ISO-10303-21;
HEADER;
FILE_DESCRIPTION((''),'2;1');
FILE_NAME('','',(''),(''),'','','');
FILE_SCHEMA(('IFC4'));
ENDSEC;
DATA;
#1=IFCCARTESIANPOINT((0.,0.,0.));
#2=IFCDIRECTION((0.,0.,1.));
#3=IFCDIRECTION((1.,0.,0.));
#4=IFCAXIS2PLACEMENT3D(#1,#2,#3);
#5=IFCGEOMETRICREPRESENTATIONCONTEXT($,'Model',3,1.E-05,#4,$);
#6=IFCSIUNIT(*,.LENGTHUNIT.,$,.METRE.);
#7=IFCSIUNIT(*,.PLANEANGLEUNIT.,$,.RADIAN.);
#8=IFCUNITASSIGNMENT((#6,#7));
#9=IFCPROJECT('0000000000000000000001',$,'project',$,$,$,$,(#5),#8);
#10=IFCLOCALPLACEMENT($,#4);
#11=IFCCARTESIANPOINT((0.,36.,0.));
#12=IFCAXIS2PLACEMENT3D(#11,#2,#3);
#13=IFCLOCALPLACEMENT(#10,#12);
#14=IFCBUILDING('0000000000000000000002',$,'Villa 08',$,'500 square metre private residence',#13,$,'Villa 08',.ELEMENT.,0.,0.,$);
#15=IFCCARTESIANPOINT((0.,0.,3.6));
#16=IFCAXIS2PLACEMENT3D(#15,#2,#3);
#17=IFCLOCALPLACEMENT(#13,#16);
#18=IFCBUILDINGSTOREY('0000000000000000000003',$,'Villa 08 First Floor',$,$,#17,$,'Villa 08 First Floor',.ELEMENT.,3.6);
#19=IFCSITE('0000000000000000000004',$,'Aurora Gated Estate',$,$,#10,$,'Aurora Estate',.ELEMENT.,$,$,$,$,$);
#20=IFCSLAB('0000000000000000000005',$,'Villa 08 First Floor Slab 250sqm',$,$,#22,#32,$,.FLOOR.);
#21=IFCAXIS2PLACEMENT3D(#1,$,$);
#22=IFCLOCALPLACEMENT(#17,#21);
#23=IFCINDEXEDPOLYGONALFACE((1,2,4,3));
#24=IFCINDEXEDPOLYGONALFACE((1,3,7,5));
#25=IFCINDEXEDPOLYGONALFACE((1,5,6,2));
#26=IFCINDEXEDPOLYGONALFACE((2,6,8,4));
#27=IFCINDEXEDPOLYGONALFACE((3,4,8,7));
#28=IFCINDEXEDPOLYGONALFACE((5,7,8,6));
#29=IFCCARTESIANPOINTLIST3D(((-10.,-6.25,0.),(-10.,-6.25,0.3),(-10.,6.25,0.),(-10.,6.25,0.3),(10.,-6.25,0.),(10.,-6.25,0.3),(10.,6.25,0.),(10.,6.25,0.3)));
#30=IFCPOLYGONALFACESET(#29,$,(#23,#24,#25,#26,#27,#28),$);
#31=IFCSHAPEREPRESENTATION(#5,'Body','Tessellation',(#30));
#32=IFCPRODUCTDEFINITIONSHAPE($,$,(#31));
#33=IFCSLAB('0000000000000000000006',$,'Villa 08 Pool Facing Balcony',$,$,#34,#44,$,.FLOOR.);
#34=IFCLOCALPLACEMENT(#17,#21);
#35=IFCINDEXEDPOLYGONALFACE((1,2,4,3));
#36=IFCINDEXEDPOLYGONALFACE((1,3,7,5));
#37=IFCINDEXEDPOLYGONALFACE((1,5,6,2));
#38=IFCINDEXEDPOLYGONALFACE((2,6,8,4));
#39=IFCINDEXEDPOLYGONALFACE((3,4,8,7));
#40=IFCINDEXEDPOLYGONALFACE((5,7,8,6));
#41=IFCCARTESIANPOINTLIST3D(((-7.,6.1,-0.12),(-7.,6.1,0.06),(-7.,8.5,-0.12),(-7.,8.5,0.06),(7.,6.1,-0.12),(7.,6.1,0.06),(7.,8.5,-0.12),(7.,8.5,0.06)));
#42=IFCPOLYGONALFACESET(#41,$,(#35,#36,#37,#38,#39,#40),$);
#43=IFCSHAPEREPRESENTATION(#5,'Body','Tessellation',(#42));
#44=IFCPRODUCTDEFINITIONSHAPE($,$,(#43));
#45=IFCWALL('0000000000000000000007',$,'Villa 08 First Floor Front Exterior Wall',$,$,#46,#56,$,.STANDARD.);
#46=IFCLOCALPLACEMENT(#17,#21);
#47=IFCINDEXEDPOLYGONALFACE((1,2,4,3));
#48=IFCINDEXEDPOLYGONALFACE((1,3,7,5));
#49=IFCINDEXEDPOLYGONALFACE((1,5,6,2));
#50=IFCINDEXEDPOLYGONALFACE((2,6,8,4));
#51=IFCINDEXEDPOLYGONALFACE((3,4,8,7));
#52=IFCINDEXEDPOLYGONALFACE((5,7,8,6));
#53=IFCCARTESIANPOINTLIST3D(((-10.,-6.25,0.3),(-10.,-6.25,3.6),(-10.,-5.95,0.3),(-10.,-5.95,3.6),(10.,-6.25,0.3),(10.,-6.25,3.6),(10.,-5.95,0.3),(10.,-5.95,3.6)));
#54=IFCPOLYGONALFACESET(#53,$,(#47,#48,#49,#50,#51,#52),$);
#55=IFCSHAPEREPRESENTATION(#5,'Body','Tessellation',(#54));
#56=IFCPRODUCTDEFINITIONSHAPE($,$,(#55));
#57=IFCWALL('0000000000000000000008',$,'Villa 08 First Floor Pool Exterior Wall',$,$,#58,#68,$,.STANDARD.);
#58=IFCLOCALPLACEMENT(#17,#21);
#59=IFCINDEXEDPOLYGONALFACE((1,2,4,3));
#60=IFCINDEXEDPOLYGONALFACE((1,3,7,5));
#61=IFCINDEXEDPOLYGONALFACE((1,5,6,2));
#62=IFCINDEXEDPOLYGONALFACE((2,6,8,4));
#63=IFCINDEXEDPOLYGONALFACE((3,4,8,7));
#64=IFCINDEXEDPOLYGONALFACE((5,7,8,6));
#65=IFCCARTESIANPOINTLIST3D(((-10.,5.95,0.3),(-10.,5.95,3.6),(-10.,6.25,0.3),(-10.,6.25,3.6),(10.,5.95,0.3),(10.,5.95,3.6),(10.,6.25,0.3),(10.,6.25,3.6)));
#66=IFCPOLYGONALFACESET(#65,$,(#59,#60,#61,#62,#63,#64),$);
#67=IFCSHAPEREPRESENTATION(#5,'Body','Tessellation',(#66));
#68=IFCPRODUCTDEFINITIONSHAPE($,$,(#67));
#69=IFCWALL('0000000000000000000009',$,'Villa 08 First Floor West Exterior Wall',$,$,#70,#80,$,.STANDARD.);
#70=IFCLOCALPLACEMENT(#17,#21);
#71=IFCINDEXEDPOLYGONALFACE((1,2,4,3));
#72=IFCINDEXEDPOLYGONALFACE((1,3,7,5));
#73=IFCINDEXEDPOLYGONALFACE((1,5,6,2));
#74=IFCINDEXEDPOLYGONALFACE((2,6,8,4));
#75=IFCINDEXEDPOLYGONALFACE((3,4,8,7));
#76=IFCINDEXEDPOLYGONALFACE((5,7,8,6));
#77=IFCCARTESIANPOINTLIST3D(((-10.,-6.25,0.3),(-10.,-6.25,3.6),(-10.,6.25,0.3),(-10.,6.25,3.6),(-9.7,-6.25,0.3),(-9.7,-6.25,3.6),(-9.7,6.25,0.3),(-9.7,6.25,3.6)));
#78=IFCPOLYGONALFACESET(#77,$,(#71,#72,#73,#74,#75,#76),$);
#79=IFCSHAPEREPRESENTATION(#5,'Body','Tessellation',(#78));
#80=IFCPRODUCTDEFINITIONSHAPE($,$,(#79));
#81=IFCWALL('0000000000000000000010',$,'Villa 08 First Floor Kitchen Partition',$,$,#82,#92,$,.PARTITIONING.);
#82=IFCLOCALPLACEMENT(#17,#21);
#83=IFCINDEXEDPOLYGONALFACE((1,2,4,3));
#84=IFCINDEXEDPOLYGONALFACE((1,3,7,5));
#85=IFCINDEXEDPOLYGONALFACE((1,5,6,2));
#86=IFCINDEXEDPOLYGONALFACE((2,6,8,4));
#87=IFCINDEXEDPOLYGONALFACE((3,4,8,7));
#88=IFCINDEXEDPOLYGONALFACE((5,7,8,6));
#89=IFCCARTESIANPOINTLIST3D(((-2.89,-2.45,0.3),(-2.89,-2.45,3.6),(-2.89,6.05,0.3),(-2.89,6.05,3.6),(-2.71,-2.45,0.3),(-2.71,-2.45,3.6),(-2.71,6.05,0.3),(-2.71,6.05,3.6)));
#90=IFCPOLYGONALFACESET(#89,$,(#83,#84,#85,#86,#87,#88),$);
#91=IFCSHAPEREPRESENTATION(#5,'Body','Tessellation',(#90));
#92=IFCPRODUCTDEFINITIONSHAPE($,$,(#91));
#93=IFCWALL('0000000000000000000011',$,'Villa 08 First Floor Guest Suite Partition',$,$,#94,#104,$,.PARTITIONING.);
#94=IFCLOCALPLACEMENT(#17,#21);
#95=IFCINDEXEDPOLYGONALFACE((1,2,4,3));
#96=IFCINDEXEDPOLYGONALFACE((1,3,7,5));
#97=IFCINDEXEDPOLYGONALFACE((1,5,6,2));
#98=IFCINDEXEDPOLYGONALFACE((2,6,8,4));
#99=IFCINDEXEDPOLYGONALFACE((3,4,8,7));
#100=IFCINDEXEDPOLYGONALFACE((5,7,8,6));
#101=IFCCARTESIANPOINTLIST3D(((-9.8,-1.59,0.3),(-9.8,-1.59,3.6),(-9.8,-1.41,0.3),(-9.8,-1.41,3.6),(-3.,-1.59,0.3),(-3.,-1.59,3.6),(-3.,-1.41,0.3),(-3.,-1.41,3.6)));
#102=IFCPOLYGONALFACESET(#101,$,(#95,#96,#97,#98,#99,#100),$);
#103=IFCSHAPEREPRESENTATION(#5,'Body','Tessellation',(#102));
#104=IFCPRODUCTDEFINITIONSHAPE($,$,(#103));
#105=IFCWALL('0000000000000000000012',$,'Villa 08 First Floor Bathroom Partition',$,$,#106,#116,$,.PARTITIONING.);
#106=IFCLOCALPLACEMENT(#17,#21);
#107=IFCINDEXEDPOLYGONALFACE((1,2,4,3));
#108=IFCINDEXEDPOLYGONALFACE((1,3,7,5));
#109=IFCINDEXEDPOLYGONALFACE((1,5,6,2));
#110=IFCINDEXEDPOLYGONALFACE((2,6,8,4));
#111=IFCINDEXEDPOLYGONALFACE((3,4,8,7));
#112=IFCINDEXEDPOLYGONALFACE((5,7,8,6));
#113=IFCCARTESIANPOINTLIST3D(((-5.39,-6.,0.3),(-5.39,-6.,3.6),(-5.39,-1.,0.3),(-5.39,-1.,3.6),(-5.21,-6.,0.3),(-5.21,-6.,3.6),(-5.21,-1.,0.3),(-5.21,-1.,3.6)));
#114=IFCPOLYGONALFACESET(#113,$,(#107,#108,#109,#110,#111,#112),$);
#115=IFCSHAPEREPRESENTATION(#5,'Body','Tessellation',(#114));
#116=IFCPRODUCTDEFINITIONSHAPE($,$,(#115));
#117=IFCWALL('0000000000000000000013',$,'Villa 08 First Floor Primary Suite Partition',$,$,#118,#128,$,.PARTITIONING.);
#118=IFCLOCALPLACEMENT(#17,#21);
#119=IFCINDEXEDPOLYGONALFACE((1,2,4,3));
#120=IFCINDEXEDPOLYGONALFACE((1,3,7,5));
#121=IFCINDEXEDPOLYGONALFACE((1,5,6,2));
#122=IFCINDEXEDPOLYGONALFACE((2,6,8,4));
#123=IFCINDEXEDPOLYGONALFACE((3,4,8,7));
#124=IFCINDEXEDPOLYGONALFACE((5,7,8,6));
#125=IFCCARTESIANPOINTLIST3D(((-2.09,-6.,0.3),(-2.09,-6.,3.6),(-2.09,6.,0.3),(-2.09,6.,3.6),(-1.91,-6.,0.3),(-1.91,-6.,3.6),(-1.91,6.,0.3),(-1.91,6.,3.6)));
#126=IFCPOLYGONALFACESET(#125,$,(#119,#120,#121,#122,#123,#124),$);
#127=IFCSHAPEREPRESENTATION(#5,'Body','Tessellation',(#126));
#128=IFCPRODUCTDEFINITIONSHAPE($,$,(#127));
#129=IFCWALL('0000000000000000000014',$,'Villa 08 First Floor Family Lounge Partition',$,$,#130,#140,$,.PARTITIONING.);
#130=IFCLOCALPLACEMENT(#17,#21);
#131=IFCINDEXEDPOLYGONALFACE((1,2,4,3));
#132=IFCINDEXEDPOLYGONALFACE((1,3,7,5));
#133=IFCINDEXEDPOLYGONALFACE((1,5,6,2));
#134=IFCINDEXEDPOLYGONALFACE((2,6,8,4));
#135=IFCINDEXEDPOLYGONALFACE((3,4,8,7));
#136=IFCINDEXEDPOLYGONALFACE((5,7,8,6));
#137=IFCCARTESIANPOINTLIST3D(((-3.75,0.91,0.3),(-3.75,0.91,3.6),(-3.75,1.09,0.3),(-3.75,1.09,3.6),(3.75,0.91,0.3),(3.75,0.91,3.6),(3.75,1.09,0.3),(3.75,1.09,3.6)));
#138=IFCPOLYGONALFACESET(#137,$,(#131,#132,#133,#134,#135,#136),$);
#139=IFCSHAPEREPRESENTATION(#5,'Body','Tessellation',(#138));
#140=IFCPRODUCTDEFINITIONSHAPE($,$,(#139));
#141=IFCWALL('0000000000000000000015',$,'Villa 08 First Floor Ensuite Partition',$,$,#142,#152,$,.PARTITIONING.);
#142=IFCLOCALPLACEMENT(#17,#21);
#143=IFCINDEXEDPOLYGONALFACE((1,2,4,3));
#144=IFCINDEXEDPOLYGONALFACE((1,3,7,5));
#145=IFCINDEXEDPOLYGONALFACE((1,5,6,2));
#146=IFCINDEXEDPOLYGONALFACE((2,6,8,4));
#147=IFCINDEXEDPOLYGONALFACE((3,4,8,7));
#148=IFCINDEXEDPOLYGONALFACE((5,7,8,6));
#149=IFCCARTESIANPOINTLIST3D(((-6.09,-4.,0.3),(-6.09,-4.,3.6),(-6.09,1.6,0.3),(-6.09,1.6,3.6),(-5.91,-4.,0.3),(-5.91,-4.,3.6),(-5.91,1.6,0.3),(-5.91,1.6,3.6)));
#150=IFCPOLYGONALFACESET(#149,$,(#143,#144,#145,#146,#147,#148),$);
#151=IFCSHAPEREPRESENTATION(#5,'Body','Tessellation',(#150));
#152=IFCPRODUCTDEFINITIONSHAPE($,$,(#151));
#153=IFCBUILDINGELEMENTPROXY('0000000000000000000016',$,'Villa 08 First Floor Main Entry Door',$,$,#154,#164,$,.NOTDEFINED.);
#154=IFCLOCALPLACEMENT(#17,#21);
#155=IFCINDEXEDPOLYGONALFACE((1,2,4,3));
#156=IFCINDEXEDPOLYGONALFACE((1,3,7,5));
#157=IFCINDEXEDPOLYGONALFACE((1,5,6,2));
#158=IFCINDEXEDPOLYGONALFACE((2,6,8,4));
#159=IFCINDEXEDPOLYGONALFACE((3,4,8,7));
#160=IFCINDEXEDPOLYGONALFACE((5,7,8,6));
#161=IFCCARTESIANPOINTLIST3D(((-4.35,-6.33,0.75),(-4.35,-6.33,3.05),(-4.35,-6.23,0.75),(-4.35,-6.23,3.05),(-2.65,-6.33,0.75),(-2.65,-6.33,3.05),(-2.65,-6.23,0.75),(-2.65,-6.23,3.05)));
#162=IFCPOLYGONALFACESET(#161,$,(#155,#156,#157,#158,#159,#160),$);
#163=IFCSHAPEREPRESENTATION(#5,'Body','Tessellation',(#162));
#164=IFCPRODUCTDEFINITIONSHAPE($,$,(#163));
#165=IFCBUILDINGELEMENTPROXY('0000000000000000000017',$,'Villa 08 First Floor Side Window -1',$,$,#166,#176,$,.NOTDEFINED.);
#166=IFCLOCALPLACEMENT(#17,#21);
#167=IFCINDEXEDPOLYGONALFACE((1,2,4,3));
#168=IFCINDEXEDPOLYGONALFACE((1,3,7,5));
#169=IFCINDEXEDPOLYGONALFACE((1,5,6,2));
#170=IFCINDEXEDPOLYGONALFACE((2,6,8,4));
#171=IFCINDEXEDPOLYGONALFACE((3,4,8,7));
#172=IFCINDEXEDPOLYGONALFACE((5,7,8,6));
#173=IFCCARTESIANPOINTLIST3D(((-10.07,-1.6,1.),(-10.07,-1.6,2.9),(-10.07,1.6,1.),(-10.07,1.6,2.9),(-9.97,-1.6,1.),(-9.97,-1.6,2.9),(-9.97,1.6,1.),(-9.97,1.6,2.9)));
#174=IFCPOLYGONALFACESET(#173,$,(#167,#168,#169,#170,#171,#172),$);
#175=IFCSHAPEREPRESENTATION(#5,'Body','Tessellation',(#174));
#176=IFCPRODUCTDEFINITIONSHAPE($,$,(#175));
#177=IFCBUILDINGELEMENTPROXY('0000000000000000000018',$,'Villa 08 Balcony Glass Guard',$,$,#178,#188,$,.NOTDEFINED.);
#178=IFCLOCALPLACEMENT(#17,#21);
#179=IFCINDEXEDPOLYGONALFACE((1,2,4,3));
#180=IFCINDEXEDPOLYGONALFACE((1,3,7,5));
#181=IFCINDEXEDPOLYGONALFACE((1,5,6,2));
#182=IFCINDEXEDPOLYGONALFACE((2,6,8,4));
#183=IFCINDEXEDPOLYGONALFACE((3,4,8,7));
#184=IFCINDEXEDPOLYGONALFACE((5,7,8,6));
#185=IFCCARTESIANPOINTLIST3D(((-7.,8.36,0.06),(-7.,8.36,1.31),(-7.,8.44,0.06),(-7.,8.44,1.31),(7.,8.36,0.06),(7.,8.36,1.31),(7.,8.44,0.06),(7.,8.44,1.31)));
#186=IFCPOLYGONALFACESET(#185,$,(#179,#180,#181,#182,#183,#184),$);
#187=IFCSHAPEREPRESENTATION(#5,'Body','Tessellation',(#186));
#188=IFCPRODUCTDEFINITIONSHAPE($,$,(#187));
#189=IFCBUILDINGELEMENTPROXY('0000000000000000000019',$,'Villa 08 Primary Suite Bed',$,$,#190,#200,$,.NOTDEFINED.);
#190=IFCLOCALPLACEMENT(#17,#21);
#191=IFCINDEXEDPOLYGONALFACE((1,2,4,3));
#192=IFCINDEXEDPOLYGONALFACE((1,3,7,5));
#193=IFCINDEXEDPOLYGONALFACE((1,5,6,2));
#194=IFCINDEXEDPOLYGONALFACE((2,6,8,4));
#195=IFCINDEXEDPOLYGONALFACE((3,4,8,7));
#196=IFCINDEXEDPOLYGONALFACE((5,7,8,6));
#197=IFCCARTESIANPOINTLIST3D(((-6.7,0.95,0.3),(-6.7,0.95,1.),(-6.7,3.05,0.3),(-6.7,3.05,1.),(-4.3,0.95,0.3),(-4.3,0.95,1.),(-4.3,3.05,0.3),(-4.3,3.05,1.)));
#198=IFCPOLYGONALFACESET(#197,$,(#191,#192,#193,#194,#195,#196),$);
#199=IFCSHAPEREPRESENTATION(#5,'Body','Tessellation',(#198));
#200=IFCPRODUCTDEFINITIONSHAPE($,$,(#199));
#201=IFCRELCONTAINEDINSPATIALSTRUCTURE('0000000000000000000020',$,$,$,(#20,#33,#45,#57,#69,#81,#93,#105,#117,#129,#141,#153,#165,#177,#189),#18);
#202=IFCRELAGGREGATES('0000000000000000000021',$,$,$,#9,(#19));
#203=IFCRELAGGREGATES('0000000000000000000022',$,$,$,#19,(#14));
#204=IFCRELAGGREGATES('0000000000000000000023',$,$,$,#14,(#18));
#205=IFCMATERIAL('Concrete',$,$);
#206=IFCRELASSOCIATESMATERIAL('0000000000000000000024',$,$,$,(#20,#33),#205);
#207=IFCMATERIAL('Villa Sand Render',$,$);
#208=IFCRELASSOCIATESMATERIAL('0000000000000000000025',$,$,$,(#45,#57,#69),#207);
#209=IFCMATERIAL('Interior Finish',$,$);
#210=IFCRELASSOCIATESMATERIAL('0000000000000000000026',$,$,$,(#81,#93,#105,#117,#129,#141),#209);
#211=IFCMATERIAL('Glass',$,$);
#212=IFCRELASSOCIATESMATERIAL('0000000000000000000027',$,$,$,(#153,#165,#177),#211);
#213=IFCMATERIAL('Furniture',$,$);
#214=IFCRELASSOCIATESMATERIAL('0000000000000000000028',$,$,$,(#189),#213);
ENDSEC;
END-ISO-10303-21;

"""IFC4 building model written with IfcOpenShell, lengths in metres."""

from ifc_helpers import new_model, si_unit, frame, origin_with_axes, origin_2d_with_axis, place, context, project, spatial, rectangle, extrude, material, element, save


model = new_model("IFC4")

# Units and contexts
model_context = context("Model", 3, precision=1e-05, world=origin_with_axes())
ifc_project = project(units=[si_unit("LENGTHUNIT", "METRE"), si_unit("PLANEANGLEUNIT", "RADIAN")], contexts=[model_context])

# Site, building, storey
site_placement = place(None, origin_with_axes())
site = spatial("IfcSite", under=ifc_project, at=site_placement, Name="Aurora Gated Estate", LongName="Aurora Estate", CompositionType="ELEMENT")
building_placement = place(site_placement, frame((0.0, 36.0, 0.0), z_axis=(0.0, 0.0, 1.0), x_axis=(1.0, 0.0, 0.0)))
building = spatial("IfcBuilding", under=site, at=building_placement, Name="Villa 08", ObjectType="500 square metre private residence", LongName="Villa 08", CompositionType="ELEMENT", ElevationOfRefHeight=0.0, ElevationOfTerrain=0.0)
storey_placement = place(building_placement, frame((0.0, 0.0, 3.6), z_axis=(0.0, 0.0, 1.0), x_axis=(1.0, 0.0, 0.0)))
storey = spatial("IfcBuildingStorey", under=building, at=storey_placement, Name="Villa 08 First Floor", LongName="Villa 08 First Floor", CompositionType="ELEMENT", Elevation=3.6)

# Slabs
ifc_material_1 = material(Name="Concrete")
slab_1_placement = place(storey_placement, origin_with_axes())
element("IfcSlab", 1, at=slab_1_placement, inside=storey, material=ifc_material_1, Name="Villa 08 First Floor Slab 250sqm", PredefinedType="FLOOR", context=model_context, shape_type="SweptSolid", body=[
    extrude(rectangle(XDim=20.0, YDim=12.5, at=origin_2d_with_axis()), origin_with_axes(), (0.0, 0.0, 1.0), 0.3),
])
slab_2_placement = place(storey_placement, frame((0.0, 7.3, -0.12), z_axis=(0.0, 0.0, 1.0), x_axis=(1.0, 0.0, 0.0)))
element("IfcSlab", 2, at=slab_2_placement, inside=storey, material=ifc_material_1, Name="Villa 08 Pool Facing Balcony", PredefinedType="FLOOR", context=model_context, shape_type="SweptSolid", body=[
    extrude(rectangle(XDim=14.0, YDim=2.4, at=origin_2d_with_axis()), origin_with_axes(), (0.0, 0.0, 1.0), 0.18),
])

# Walls
ifc_material_2 = material(Name="Villa Sand Render")
for number, where, z_axis, x_axis, name in (
    (3, (0.0, -6.1, 0.3), (0.0, 0.0, 1.0), (1.0, 0.0, 0.0), "Villa 08 First Floor Front Exterior Wall"),
    (4, (0.0, 6.1, 0.3), (0.0, 0.0, 1.0), (1.0, 0.0, 0.0), "Villa 08 First Floor Pool Exterior Wall"),
):
    element("IfcWall", number, at=place(storey_placement, frame(where, z_axis=z_axis, x_axis=x_axis)), inside=storey, material=ifc_material_2, Name=name, PredefinedType="STANDARD", context=model_context, shape_type="SweptSolid", body=[
        extrude(rectangle(XDim=20.0, YDim=0.3, at=origin_2d_with_axis()), origin_with_axes(), (0.0, 0.0, 1.0), 3.3),
    ])
wall_1_placement = place(storey_placement, frame((-9.85, 0.0, 0.3), z_axis=(0.0, 0.0, 1.0), x_axis=(1.0, 0.0, 0.0)))
element("IfcWall", 5, at=wall_1_placement, inside=storey, material=ifc_material_2, Name="Villa 08 First Floor West Exterior Wall", PredefinedType="STANDARD", context=model_context, shape_type="SweptSolid", body=[
    extrude(rectangle(XDim=0.3, YDim=12.5, at=origin_2d_with_axis()), origin_with_axes(), (0.0, 0.0, 1.0), 3.3),
])
ifc_material_3 = material(Name="Interior Finish")
wall_2_placement = place(storey_placement, frame((-2.8, 1.8, 0.3), z_axis=(0.0, 0.0, 1.0), x_axis=(1.0, 0.0, 0.0)))
element("IfcWall", 6, at=wall_2_placement, inside=storey, material=ifc_material_3, Name="Villa 08 First Floor Kitchen Partition", PredefinedType="PARTITIONING", context=model_context, shape_type="SweptSolid", body=[
    extrude(rectangle(XDim=0.18, YDim=8.5, at=origin_2d_with_axis()), origin_with_axes(), (0.0, 0.0, 1.0), 3.3),
])
wall_3_placement = place(storey_placement, frame((-6.4, -1.5, 0.3), z_axis=(0.0, 0.0, 1.0), x_axis=(1.0, 0.0, 0.0)))
element("IfcWall", 7, at=wall_3_placement, inside=storey, material=ifc_material_3, Name="Villa 08 First Floor Guest Suite Partition", PredefinedType="PARTITIONING", context=model_context, shape_type="SweptSolid", body=[
    extrude(rectangle(XDim=6.8, YDim=0.18, at=origin_2d_with_axis()), origin_with_axes(), (0.0, 0.0, 1.0), 3.3),
])
wall_4_placement = place(storey_placement, frame((-5.3, -3.5, 0.3), z_axis=(0.0, 0.0, 1.0), x_axis=(1.0, 0.0, 0.0)))
element("IfcWall", 8, at=wall_4_placement, inside=storey, material=ifc_material_3, Name="Villa 08 First Floor Bathroom Partition", PredefinedType="PARTITIONING", context=model_context, shape_type="SweptSolid", body=[
    extrude(rectangle(XDim=0.18, YDim=5.0, at=origin_2d_with_axis()), origin_with_axes(), (0.0, 0.0, 1.0), 3.3),
])
wall_5_placement = place(storey_placement, frame((-2.0, 0.0, 0.3), z_axis=(0.0, 0.0, 1.0), x_axis=(1.0, 0.0, 0.0)))
element("IfcWall", 9, at=wall_5_placement, inside=storey, material=ifc_material_3, Name="Villa 08 First Floor Primary Suite Partition", PredefinedType="PARTITIONING", context=model_context, shape_type="SweptSolid", body=[
    extrude(rectangle(XDim=0.18, YDim=12.0, at=origin_2d_with_axis()), origin_with_axes(), (0.0, 0.0, 1.0), 3.3),
])
wall_6_placement = place(storey_placement, frame((0.0, 1.0, 0.3), z_axis=(0.0, 0.0, 1.0), x_axis=(1.0, 0.0, 0.0)))
element("IfcWall", 10, at=wall_6_placement, inside=storey, material=ifc_material_3, Name="Villa 08 First Floor Family Lounge Partition", PredefinedType="PARTITIONING", context=model_context, shape_type="SweptSolid", body=[
    extrude(rectangle(XDim=7.5, YDim=0.18, at=origin_2d_with_axis()), origin_with_axes(), (0.0, 0.0, 1.0), 3.3),
])
wall_7_placement = place(storey_placement, frame((-6.0, -1.2, 0.3), z_axis=(0.0, 0.0, 1.0), x_axis=(1.0, 0.0, 0.0)))
element("IfcWall", 11, at=wall_7_placement, inside=storey, material=ifc_material_3, Name="Villa 08 First Floor Ensuite Partition", PredefinedType="PARTITIONING", context=model_context, shape_type="SweptSolid", body=[
    extrude(rectangle(XDim=0.18, YDim=5.6, at=origin_2d_with_axis()), origin_with_axes(), (0.0, 0.0, 1.0), 3.3),
])

# Building element proxies
ifc_material_4 = material(Name="Glass")
proxy_1_placement = place(storey_placement, frame((-3.5, -6.28, 0.75), z_axis=(0.0, 0.0, 1.0), x_axis=(1.0, 0.0, 0.0)))
element("IfcBuildingElementProxy", 12, at=proxy_1_placement, inside=storey, material=ifc_material_4, Name="Villa 08 First Floor Main Entry Door", PredefinedType="NOTDEFINED", context=model_context, shape_type="SweptSolid", body=[
    extrude(rectangle(XDim=1.7, YDim=0.1, at=origin_2d_with_axis()), origin_with_axes(), (0.0, 0.0, 1.0), 2.3),
])
proxy_2_placement = place(storey_placement, frame((-10.02, 0.0, 1.0), z_axis=(0.0, 0.0, 1.0), x_axis=(0.0, 1.0, 0.0)))
element("IfcBuildingElementProxy", 13, at=proxy_2_placement, inside=storey, material=ifc_material_4, Name="Villa 08 First Floor Side Window -1", PredefinedType="NOTDEFINED", context=model_context, shape_type="SweptSolid", body=[
    extrude(rectangle(XDim=3.2, YDim=0.1, at=origin_2d_with_axis()), origin_with_axes(), (0.0, 0.0, 1.0), 1.9),
])
proxy_3_placement = place(storey_placement, frame((0.0, 8.4, 0.06), z_axis=(0.0, 0.0, 1.0), x_axis=(1.0, 0.0, 0.0)))
element("IfcBuildingElementProxy", 14, at=proxy_3_placement, inside=storey, material=ifc_material_4, Name="Villa 08 Balcony Glass Guard", PredefinedType="NOTDEFINED", context=model_context, shape_type="SweptSolid", body=[
    extrude(rectangle(XDim=14.0, YDim=0.08, at=origin_2d_with_axis()), origin_with_axes(), (0.0, 0.0, 1.0), 1.25),
])
ifc_material_5 = material(Name="Furniture")
proxy_4_placement = place(storey_placement, frame((-5.5, 2.0, 0.3), z_axis=(0.0, 0.0, 1.0), x_axis=(1.0, 0.0, 0.0)))
element("IfcBuildingElementProxy", 15, at=proxy_4_placement, inside=storey, material=ifc_material_5, Name="Villa 08 Primary Suite Bed", PredefinedType="NOTDEFINED", context=model_context, shape_type="SweptSolid", body=[
    extrude(rectangle(XDim=2.4, YDim=2.1, at=origin_2d_with_axis()), origin_with_axes(), (0.0, 0.0, 1.0), 0.7),
])

save(model, "model.ifc")
